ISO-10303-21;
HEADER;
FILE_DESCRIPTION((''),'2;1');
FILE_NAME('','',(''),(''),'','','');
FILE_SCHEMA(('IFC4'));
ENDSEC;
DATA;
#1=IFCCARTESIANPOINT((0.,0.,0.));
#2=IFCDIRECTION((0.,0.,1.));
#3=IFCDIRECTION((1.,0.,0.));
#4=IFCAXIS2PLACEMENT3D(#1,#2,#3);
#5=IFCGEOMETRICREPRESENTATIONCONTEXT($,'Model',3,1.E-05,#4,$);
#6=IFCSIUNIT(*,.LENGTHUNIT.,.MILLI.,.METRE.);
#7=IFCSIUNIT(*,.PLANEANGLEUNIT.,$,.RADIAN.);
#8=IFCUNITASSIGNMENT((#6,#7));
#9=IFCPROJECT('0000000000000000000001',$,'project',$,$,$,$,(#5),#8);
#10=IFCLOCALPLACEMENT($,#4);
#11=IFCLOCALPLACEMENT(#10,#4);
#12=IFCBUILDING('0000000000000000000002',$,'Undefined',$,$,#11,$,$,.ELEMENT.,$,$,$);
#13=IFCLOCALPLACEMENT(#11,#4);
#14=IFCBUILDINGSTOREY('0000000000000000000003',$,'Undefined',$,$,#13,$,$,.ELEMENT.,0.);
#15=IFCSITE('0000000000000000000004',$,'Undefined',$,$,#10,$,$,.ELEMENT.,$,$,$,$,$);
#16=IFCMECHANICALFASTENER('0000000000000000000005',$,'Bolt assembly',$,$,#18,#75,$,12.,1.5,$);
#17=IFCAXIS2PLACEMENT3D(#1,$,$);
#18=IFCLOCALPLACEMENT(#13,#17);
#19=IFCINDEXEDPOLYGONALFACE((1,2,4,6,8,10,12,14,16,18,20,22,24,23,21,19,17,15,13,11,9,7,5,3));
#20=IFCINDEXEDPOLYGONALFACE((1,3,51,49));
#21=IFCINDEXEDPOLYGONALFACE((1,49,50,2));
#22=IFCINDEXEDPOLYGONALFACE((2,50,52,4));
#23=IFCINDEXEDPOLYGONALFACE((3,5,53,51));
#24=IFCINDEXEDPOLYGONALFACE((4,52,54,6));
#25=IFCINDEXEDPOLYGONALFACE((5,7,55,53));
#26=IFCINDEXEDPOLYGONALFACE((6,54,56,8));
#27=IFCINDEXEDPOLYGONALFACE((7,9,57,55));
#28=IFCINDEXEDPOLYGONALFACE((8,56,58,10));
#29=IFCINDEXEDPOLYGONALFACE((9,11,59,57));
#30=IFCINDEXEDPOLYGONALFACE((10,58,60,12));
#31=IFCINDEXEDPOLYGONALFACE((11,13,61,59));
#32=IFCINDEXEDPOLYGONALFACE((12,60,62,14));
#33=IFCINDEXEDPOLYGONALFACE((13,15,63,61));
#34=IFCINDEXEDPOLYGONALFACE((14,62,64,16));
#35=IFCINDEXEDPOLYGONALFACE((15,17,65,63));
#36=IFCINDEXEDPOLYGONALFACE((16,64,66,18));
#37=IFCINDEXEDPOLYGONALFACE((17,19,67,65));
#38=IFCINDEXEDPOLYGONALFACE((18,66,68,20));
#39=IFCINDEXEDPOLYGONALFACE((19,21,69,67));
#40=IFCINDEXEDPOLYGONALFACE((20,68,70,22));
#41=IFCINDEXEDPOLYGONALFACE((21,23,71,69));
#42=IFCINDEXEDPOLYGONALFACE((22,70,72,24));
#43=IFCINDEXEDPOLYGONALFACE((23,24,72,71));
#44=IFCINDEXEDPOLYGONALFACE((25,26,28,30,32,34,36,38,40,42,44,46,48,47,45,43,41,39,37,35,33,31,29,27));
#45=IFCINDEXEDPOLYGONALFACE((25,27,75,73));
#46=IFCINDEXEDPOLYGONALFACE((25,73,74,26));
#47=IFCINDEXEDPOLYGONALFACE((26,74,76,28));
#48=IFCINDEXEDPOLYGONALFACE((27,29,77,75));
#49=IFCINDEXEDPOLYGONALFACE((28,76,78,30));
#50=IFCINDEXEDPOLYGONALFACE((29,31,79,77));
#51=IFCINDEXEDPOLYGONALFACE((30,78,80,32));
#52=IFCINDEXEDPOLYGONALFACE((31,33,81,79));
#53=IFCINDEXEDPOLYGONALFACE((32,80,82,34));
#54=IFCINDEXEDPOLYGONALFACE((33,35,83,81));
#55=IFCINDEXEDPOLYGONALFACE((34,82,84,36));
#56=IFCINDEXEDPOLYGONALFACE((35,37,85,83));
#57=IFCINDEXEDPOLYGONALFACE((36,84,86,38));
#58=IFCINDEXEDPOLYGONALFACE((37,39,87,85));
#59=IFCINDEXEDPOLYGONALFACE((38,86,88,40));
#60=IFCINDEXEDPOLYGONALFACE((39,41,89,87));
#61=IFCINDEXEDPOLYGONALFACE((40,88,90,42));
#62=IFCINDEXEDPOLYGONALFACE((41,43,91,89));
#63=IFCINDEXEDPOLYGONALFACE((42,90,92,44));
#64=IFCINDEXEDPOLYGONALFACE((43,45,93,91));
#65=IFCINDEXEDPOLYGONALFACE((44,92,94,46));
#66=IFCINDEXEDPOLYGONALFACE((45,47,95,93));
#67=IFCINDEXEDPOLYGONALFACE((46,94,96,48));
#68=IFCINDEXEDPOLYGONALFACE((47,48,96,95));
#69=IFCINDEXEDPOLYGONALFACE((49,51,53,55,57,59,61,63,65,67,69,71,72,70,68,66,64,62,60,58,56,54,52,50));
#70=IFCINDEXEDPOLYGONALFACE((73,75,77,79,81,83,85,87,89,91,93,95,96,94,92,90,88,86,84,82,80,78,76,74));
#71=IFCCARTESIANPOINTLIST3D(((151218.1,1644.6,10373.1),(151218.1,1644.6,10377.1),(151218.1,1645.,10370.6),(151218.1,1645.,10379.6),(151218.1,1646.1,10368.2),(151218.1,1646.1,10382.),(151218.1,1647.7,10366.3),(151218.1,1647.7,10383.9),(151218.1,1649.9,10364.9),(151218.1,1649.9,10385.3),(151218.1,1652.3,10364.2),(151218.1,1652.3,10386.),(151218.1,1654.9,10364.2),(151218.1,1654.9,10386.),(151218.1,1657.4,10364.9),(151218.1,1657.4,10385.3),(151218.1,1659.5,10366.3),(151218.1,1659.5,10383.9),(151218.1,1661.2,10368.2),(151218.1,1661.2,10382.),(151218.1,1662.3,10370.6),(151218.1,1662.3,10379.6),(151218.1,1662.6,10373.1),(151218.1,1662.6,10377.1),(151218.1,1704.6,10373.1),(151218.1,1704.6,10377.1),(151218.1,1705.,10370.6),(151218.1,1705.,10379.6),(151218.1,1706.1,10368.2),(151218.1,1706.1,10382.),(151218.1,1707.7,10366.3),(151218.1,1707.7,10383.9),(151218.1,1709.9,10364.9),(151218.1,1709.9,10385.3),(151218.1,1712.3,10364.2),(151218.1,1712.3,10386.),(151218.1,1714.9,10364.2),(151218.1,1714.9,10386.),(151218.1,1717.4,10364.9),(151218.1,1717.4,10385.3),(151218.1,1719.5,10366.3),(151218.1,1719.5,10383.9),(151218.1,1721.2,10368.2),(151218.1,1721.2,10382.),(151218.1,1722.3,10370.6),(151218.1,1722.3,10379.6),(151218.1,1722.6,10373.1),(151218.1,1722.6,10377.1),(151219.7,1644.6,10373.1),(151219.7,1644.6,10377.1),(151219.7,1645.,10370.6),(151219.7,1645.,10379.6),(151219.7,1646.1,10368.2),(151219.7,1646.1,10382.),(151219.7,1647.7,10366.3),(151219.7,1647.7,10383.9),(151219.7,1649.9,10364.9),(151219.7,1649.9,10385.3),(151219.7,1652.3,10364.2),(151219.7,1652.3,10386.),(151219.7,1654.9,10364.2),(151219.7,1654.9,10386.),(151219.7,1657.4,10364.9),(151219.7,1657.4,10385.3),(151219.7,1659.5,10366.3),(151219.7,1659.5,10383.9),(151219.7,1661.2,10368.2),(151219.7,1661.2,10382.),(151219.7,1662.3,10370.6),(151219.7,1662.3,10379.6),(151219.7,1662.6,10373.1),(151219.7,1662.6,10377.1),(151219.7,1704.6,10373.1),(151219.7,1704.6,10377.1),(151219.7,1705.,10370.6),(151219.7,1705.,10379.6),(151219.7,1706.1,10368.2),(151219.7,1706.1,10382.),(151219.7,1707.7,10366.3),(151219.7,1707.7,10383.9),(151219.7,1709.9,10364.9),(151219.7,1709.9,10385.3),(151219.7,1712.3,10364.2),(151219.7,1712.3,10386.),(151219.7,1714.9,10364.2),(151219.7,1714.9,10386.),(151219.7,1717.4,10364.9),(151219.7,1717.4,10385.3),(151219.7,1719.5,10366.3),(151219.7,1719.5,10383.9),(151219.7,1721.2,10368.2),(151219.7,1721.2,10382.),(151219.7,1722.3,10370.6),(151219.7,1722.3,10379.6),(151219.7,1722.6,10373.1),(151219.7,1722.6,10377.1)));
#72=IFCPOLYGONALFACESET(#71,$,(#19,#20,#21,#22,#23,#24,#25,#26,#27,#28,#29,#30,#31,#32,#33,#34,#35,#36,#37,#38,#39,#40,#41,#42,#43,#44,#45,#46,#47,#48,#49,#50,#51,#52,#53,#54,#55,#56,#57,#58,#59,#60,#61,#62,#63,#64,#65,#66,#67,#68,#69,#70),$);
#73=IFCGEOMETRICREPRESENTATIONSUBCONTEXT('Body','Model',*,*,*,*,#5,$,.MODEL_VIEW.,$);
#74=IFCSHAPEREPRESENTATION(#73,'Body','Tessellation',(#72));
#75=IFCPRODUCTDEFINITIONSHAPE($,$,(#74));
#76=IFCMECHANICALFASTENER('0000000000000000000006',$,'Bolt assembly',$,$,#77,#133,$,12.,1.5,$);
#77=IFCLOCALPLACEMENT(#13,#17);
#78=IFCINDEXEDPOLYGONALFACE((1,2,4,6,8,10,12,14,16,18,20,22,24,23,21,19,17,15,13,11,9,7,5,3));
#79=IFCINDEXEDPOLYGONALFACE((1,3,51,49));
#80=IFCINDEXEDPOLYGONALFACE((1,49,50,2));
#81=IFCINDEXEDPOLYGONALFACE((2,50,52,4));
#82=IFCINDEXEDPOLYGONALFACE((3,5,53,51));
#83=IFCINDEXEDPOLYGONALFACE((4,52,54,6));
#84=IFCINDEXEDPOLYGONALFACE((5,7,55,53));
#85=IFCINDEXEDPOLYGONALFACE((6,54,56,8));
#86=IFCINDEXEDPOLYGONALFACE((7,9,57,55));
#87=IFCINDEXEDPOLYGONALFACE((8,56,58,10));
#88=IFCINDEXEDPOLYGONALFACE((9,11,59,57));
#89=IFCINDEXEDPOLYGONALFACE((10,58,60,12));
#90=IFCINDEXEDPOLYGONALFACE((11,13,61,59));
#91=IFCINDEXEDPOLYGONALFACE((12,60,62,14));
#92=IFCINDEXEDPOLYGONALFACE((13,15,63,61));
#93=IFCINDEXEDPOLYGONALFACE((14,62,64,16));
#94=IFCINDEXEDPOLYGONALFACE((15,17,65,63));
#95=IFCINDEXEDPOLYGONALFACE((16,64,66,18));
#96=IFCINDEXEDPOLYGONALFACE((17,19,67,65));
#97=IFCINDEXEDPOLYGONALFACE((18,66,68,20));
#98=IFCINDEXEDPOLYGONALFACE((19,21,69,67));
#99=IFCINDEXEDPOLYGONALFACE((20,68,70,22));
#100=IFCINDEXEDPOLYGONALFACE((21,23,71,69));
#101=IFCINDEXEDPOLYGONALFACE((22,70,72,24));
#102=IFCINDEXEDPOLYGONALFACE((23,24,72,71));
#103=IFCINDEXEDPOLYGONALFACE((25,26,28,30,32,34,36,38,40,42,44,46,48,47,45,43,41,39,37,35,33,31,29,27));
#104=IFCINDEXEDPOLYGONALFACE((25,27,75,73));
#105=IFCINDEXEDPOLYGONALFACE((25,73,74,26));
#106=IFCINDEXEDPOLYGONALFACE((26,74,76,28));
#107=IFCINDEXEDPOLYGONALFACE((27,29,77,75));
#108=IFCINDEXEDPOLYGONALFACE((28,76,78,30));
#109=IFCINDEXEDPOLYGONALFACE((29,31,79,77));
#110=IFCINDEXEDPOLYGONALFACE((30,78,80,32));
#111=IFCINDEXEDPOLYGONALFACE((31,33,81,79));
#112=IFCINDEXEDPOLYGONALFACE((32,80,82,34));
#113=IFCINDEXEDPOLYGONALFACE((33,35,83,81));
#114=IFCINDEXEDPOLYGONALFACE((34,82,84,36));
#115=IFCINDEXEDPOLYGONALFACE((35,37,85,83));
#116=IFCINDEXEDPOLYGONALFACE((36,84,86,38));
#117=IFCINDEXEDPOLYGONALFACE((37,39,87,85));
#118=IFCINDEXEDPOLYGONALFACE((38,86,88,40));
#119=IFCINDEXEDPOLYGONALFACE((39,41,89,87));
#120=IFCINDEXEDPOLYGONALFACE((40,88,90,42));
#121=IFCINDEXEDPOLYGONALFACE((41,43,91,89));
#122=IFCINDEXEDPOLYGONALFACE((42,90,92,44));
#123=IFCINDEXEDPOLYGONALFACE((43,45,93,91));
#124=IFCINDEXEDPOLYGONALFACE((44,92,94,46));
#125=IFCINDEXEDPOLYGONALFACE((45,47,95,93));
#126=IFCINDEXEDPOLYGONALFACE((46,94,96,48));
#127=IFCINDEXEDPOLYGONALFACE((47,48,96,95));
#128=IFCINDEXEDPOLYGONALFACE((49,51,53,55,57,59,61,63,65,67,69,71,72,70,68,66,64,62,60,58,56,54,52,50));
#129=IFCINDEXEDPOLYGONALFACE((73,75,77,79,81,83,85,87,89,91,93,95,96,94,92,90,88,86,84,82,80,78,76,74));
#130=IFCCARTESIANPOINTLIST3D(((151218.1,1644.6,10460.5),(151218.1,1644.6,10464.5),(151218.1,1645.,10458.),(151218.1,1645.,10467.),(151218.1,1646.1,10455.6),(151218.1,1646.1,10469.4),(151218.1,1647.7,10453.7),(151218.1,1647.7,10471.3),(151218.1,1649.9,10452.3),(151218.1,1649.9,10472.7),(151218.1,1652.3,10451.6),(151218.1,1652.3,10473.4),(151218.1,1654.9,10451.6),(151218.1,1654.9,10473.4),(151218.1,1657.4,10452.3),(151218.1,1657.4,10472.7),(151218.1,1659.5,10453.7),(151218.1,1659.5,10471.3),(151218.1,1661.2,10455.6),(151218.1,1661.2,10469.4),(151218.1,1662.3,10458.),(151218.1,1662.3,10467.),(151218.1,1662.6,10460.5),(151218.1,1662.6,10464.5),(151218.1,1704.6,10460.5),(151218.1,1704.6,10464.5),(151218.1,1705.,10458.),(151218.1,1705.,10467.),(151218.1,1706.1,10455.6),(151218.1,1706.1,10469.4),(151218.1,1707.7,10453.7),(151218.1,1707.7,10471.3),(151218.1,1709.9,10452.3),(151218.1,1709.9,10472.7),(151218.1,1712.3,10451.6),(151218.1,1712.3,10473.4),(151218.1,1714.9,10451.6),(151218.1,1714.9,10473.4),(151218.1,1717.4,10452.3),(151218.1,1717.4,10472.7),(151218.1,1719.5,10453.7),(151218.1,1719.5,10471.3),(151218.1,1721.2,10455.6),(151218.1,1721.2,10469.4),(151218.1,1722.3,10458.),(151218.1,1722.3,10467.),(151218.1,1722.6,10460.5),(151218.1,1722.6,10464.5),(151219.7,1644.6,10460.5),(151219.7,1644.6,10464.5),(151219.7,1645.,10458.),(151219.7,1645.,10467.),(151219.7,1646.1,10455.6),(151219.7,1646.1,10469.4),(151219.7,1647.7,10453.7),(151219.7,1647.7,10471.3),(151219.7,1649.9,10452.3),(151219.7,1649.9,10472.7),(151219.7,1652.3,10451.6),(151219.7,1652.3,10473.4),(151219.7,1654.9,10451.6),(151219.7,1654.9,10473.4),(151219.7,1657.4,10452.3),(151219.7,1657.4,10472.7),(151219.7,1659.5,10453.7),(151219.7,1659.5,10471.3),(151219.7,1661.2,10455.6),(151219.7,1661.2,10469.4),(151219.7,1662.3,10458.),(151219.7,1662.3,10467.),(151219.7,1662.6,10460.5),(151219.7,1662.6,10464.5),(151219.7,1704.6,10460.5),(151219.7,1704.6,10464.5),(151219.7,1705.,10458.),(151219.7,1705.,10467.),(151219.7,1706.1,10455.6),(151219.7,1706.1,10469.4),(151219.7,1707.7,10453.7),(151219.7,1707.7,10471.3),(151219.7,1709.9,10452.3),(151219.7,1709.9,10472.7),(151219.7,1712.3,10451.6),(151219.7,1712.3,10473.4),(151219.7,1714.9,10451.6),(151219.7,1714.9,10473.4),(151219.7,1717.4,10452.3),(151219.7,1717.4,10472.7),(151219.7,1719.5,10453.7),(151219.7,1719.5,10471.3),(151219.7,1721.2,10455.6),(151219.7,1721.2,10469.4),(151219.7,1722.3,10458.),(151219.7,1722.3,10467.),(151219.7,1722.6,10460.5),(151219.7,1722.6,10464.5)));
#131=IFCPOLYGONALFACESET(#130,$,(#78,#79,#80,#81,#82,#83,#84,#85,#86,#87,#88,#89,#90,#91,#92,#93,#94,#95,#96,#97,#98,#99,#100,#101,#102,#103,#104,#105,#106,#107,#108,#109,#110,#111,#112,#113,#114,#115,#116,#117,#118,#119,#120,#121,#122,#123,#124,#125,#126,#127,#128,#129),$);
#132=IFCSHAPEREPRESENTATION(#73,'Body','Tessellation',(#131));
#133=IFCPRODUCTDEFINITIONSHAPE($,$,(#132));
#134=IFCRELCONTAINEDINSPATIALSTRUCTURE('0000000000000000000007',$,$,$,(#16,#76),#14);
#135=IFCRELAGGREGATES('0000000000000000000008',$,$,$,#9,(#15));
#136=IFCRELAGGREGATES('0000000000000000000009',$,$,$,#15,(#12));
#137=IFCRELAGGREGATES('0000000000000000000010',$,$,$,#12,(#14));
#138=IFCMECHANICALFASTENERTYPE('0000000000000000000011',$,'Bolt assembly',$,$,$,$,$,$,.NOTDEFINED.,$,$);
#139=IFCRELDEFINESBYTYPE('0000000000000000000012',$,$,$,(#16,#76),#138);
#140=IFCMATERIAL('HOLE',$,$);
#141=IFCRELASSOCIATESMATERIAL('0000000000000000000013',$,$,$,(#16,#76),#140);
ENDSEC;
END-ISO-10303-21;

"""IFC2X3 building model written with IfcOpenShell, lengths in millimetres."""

from ifc_helpers import new_model, si_unit, frame, frame_2d, origin_with_axes, place, context, subcontext, project, spatial, polyline, circle_curve, parameter, trimmed, segment, composite_curve, outline, extrude, source, transform, mapped, material, type_object, element, save


model = new_model("IFC2X3")

# Units and contexts
model_context = context("Model", 3, precision=1e-05, world=origin_with_axes())
body_context = subcontext(model_context, "Body", "Model", "MODEL_VIEW")
ifc_project = project(units=[si_unit("LENGTHUNIT", "METRE", prefix="MILLI"), si_unit("PLANEANGLEUNIT", "RADIAN")], contexts=[model_context])

# Site, building, storey
site_placement = place(None, origin_with_axes())
site = spatial("IfcSite", under=ifc_project, at=site_placement, Name="Undefined", CompositionType="ELEMENT")
building_placement = place(site_placement, origin_with_axes())
building = spatial("IfcBuilding", under=site, at=building_placement, Name="Undefined", CompositionType="ELEMENT")
storey_placement = place(building_placement, origin_with_axes())
storey = spatial("IfcBuildingStorey", under=building, at=storey_placement, Name="Undefined", CompositionType="ELEMENT", Elevation=0.0)

# Mechanical fasteners
ifc_material_1 = material(Name="HOLE")
mechanical_fastener_type = type_object("IfcMechanicalFastenerType", Name="Bolt assembly")
shared_shape_1 = source(origin_with_axes(), body_context, "Body", "SweptSolid", [
    extrude(outline(composite_curve([segment(polyline([(9.0, 2.0), (9.0, -2.0)]), True, "CONTINUOUS"), segment(trimmed(circle_curve(frame_2d((0.0, -2.0), x_axis=(1.0, 0.0)), 9.0), [parameter(0.0)], [parameter(3.141593)], False, "PARAMETER"), True, "CONTINUOUS"), segment(polyline([(-9.0, -2.0), (-9.0, 2.0)]), True, "CONTINUOUS"), segment(trimmed(circle_curve(frame_2d((0.0, 2.0), x_axis=(-1.0, 0.0)), 9.0), [parameter(0.0)], [parameter(3.141593)], False, "PARAMETER"), True, "DISCONTINUOUS")], self_intersect=False)), frame((0.0, 0.0, 0.0), z_axis=(0.0, 1.0, 0.0), x_axis=(1.0, 0.0, 0.0)), (0.0, 0.0, 1.0), 1.6),
])
mechanical_fastener_1_placement = place(storey_placement, frame((151218.1, 1653.6, 10375.1), z_axis=(0.0, 0.0, -1.0), x_axis=(0.0, 1.0, 0.0)))
element("IfcMechanicalFastener", 1, at=mechanical_fastener_1_placement, inside=storey, type_object=mechanical_fastener_type, material=ifc_material_1, Name="Bolt assembly", NominalDiameter=12.0, NominalLength=1.5, context=body_context, shape_type="MappedRepresentation", body=[
    mapped(shared_shape_1, transform((0.0, 0.0, 0.0))),
    mapped(shared_shape_1, transform((60.0, 0.0, 0.0))),
])
shared_shape_2 = source(origin_with_axes(), body_context, "Body", "SweptSolid", [
    extrude(outline(composite_curve([segment(polyline([(9.0, 2.0), (9.0, -2.0)]), True, "CONTINUOUS"), segment(trimmed(circle_curve(frame_2d((0.0, -2.0), x_axis=(1.0, 0.0)), 9.0), [parameter(0.0)], [parameter(3.141593)], False, "PARAMETER"), True, "CONTINUOUS"), segment(polyline([(-9.0, -2.0), (-9.0, 2.0)]), True, "CONTINUOUS"), segment(trimmed(circle_curve(frame_2d((0.0, 2.0), x_axis=(-1.0, 0.0)), 9.0), [parameter(0.0)], [parameter(3.141593)], False, "PARAMETER"), True, "DISCONTINUOUS")], self_intersect=False)), frame((0.0, 0.0, 0.0), z_axis=(0.0, 1.0, 0.0), x_axis=(1.0, 0.0, 0.0)), (0.0, 0.0, 1.0), 1.6),
])
mechanical_fastener_2_placement = place(storey_placement, frame((151218.1, 1653.6, 10462.5), z_axis=(0.0, 0.0, -1.0), x_axis=(0.0, 1.0, 0.0)))
element("IfcMechanicalFastener", 2, at=mechanical_fastener_2_placement, inside=storey, type_object=mechanical_fastener_type, material=ifc_material_1, Name="Bolt assembly", NominalDiameter=12.0, NominalLength=1.5, context=body_context, shape_type="MappedRepresentation", body=[
    mapped(shared_shape_2, transform((0.0, 0.0, 0.0))),
    mapped(shared_shape_2, transform((60.0, 0.0, 0.0))),
])

save(model, "model.ifc")
